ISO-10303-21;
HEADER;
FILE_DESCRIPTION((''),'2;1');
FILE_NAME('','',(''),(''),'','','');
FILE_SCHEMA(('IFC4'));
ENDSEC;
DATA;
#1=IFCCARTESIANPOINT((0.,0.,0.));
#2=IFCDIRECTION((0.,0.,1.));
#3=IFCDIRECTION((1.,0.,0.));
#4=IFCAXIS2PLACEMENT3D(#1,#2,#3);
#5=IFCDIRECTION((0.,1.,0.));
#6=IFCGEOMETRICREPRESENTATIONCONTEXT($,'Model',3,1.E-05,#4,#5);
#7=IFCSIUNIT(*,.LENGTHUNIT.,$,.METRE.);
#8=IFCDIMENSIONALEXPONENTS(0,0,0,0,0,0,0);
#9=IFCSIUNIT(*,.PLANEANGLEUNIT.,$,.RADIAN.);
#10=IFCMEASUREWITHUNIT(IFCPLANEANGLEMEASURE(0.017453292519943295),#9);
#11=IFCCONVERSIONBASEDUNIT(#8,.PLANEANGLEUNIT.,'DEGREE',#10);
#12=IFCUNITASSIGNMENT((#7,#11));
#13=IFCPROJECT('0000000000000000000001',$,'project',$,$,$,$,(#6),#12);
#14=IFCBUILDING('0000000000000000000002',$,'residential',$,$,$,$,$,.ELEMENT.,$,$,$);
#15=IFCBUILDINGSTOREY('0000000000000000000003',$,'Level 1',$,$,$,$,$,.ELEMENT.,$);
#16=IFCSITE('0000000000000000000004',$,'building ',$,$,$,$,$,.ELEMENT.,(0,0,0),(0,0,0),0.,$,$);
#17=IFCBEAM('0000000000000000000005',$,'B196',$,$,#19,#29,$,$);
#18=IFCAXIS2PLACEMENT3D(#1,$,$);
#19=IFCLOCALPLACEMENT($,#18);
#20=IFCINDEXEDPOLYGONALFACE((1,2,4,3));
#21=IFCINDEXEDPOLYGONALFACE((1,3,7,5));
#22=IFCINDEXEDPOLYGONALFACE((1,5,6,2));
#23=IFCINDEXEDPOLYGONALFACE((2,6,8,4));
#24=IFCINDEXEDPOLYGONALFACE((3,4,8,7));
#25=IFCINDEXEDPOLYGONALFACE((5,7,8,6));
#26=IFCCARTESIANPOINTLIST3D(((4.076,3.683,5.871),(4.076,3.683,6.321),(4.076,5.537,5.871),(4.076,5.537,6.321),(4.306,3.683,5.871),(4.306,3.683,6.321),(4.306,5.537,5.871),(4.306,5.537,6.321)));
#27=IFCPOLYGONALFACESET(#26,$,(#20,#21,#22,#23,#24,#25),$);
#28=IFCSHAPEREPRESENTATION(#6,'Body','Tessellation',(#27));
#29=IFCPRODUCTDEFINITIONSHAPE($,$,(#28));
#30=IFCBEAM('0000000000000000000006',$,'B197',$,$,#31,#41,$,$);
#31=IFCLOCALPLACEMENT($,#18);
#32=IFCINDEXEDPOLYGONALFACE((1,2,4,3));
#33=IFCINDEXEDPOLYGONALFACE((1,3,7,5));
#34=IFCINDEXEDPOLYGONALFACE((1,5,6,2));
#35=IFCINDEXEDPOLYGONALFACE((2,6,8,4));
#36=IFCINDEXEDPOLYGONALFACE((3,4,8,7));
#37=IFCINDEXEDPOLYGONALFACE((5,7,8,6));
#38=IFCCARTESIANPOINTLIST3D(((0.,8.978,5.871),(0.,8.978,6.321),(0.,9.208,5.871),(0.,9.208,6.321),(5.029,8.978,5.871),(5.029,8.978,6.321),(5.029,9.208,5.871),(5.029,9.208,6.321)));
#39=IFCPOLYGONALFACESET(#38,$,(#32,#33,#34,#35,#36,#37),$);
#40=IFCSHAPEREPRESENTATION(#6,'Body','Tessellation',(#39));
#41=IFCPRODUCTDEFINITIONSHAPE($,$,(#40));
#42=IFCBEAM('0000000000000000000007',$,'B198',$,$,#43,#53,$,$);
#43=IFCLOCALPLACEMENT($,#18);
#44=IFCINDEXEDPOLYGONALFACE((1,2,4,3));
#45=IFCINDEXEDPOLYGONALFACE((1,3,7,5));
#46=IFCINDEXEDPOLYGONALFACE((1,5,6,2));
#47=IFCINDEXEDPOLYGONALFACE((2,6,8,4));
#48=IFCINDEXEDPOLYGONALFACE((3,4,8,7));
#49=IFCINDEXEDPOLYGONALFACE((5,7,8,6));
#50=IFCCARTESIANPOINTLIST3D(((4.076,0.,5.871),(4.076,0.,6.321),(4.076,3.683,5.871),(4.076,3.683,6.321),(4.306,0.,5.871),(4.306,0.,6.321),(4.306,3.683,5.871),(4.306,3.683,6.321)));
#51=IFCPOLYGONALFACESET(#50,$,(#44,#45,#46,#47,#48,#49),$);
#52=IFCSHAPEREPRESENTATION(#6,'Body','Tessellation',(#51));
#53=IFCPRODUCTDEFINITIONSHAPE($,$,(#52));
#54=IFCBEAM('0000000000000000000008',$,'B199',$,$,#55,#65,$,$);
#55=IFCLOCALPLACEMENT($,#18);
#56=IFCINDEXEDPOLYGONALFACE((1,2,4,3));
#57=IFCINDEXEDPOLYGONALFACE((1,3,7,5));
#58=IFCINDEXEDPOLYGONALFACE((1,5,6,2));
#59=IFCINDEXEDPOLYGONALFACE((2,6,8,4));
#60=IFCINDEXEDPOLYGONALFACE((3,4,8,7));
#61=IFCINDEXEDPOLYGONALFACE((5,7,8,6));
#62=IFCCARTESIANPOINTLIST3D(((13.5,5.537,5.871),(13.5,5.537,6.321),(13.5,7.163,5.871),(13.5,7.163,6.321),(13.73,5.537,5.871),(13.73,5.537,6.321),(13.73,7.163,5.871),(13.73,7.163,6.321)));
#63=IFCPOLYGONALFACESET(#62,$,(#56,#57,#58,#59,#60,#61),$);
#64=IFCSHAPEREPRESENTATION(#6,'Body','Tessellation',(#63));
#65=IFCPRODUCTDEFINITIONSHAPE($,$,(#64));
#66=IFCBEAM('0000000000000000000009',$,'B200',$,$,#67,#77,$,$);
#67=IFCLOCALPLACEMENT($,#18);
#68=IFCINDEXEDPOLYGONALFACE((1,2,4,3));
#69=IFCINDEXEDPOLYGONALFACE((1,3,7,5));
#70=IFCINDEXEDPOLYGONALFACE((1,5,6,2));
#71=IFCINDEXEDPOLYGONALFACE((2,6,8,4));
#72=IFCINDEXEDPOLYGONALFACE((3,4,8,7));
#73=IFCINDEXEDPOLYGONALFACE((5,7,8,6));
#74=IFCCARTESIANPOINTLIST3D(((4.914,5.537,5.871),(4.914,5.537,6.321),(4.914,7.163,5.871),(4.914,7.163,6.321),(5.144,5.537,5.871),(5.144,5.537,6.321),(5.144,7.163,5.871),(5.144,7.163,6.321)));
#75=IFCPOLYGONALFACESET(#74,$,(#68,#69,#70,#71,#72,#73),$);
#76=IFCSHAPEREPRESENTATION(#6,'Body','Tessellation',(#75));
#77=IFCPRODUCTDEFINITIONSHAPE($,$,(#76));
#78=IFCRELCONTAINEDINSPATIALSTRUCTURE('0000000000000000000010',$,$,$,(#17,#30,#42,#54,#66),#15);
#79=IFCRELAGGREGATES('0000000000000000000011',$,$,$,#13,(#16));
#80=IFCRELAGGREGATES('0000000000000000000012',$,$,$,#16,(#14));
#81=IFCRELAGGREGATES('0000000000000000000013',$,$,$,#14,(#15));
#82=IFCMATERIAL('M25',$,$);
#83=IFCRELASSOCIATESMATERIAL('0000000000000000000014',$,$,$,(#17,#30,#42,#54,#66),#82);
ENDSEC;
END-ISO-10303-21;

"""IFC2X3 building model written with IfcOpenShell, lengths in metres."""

from ifc_helpers import new_model, entity, si_unit, converted_unit, direction, frame, frame_2d, origin_with_axes, place, context, project, spatial, rectangle, extrude, material, element, save


model = new_model("IFC2X3")

# Units and contexts
model_context = context("Model", 3, precision=1e-05, world=origin_with_axes(), true_north=direction((0.0, 1.0, 0.0)))
ifc_project = project(units=[si_unit("LENGTHUNIT", "METRE"), converted_unit("PLANEANGLEUNIT", "DEGREE", entity("IfcPlaneAngleMeasure", 0.017453292519943295), si_unit("PLANEANGLEUNIT", "RADIAN"), dimensions=[0, 0, 0, 0, 0, 0, 0])], contexts=[model_context])

# Site, building, storey
site = spatial("IfcSite", under=ifc_project, Name="building ", CompositionType="ELEMENT", RefLatitude=(0, 0, 0), RefLongitude=(0, 0, 0), RefElevation=0.0)
building = spatial("IfcBuilding", under=site, Name="residential", CompositionType="ELEMENT")
storey = spatial("IfcBuildingStorey", under=building, Name="Level 1", CompositionType="ELEMENT")

# Beams
ifc_material = material(Name="M25")
placement = place(None, origin_with_axes())
element("IfcBeam", 1, at=placement, inside=storey, material=ifc_material, Name="B196", context=model_context, shape_type="SweptSolid", body=[
    extrude(rectangle(XDim=0.23, YDim=0.45, at=frame_2d((0.0, 0.0), x_axis=(0.0, 1.0, 0.0))), frame((4.191, 3.683, 6.096), z_axis=(0.0, 1.0, 0.0), x_axis=(0.0, 0.0, -1.0)), (0.0, 0.0, 1.0), 1.854),
])
element("IfcBeam", 2, at=placement, inside=storey, material=ifc_material, Name="B197", context=model_context, shape_type="SweptSolid", body=[
    extrude(rectangle(XDim=0.23, YDim=0.45, at=frame_2d((0.0, 0.0), x_axis=(0.0, 1.0, 0.0))), frame((0.0, 9.093, 6.096), z_axis=(1.0, 0.0, 0.0), x_axis=(0.0, 0.0, -1.0)), (0.0, 0.0, 1.0), 5.029),
])
element("IfcBeam", 3, at=placement, inside=storey, material=ifc_material, Name="B198", context=model_context, shape_type="SweptSolid", body=[
    extrude(rectangle(XDim=0.23, YDim=0.45, at=frame_2d((0.0, 0.0), x_axis=(0.0, 1.0, 0.0))), frame((4.191, 0.0, 6.096), z_axis=(0.0, 1.0, 0.0), x_axis=(0.0, 0.0, -1.0)), (0.0, 0.0, 1.0), 3.683),
])
element("IfcBeam", 4, at=placement, inside=storey, material=ifc_material, Name="B199", context=model_context, shape_type="SweptSolid", body=[
    extrude(rectangle(XDim=0.23, YDim=0.45, at=frame_2d((0.0, 0.0), x_axis=(0.0, 1.0, 0.0))), frame((13.615, 5.537, 6.096), z_axis=(0.0, 1.0, 0.0), x_axis=(0.0, 0.0, -1.0)), (0.0, 0.0, 1.0), 1.626),
])
element("IfcBeam", 5, at=placement, inside=storey, material=ifc_material, Name="B200", context=model_context, shape_type="SweptSolid", body=[
    extrude(rectangle(XDim=0.23, YDim=0.45, at=frame_2d((0.0, 0.0), x_axis=(0.0, 1.0, 0.0))), frame((5.029, 5.537, 6.096), z_axis=(0.0, 1.0, 0.0), x_axis=(0.0, 0.0, -1.0)), (0.0, 0.0, 1.0), 1.626),
])

save(model, "model.ifc")
